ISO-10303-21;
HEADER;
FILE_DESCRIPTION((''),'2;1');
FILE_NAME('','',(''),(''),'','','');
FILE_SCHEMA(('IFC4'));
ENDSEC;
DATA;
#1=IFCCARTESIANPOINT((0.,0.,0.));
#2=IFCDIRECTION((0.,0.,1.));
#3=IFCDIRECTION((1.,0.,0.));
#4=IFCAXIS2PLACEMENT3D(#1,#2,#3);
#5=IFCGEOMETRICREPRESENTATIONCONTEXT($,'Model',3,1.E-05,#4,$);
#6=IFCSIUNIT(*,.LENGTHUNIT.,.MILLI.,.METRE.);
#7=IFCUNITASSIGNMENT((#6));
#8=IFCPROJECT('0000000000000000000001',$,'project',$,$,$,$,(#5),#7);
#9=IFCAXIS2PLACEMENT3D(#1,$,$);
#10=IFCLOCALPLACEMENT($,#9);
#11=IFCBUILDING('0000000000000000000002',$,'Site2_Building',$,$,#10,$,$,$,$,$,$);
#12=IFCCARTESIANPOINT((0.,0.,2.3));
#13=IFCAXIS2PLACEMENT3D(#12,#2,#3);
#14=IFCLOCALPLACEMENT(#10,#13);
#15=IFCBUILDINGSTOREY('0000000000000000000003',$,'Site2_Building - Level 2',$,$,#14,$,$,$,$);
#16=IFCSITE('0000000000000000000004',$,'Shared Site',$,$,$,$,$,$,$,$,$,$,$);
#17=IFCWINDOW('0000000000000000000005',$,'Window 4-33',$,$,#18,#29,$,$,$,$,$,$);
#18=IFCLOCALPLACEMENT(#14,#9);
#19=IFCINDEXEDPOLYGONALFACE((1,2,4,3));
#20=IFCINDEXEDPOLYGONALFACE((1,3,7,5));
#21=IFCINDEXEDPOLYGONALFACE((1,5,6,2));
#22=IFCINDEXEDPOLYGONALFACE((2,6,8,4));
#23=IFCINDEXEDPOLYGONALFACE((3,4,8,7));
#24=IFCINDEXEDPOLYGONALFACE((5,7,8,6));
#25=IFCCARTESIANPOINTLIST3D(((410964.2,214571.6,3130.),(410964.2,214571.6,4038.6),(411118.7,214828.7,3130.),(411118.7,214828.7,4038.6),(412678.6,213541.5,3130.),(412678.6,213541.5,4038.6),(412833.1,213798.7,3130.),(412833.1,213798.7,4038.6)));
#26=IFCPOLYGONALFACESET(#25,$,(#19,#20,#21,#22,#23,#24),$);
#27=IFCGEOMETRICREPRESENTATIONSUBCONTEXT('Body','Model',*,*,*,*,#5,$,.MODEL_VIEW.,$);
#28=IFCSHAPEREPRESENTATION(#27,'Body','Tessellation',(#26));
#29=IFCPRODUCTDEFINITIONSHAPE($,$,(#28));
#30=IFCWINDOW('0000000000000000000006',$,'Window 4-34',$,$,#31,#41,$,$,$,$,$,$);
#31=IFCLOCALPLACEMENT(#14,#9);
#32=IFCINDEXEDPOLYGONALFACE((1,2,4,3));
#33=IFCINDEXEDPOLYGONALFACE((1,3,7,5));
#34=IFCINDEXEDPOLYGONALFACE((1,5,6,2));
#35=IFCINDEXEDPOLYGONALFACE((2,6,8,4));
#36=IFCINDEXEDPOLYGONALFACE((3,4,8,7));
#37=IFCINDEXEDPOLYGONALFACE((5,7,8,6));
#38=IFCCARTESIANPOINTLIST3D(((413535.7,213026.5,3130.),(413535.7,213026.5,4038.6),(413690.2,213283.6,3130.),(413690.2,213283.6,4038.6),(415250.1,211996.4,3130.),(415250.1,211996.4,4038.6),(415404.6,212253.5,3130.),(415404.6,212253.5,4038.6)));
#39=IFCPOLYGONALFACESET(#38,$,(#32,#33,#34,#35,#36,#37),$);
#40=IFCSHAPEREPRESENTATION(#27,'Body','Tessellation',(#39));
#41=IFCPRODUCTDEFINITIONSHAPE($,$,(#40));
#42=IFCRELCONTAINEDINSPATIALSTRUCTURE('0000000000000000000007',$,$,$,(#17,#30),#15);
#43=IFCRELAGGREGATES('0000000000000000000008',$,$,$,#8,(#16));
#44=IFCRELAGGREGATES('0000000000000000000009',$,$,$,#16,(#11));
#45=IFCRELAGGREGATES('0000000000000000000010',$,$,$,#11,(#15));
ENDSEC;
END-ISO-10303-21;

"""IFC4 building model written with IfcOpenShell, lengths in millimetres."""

from ifc_helpers import new_model, si_unit, frame, origin, origin_with_axes, place, context, subcontext, project, spatial, indexed_curve, outline, extrude, element, save


model = new_model("IFC4")

# Units and contexts
model_context = context("Model", 3, precision=1e-05, world=origin_with_axes())
body_context = subcontext(model_context, "Body", "Model", "MODEL_VIEW")
ifc_project = project(units=[si_unit("LENGTHUNIT", "METRE", prefix="MILLI")], contexts=[model_context])

# Site, building, storey
site = spatial("IfcSite", under=ifc_project, Name="Shared Site")
building_placement = place(None, origin())
building = spatial("IfcBuilding", under=site, at=building_placement, Name="Site2_Building")
storey_placement = place(building_placement, frame((0.0, 0.0, 2.3), z_axis=(0.0, 0.0, 1.0), x_axis=(1.0, 0.0, 0.0)))
storey = spatial("IfcBuildingStorey", under=building, at=storey_placement, Name="Site2_Building - Level 2")

# Windows
for number, where, z_axis, x_axis, name in (
    (1, (410964.2, 214571.6, 3130.0), (0.0, 0.0, 1.0), (0.857167, -0.515038, 0.0), "Window 4-33"),
    (2, (413535.7, 213026.5, 3130.0), (0.0, 0.0, 1.0), (0.857167, -0.515038, 0.0), "Window 4-34"),
):
    element("IfcWindow", number, at=place(storey_placement, frame(where, z_axis=z_axis, x_axis=x_axis)), inside=storey, Name=name, context=body_context, shape_type="SweptSolid", body=[
        extrude(outline(indexed_curve([(0.0, 0.0), (0.0, 300.0), (2000.0, 300.0), (2000.0, 0.0), (0.0, 0.0)], self_intersect=False)), origin_with_axes(), (0.0, 0.0, 1.0), 908.6),
    ])

save(model, "model.ifc")
